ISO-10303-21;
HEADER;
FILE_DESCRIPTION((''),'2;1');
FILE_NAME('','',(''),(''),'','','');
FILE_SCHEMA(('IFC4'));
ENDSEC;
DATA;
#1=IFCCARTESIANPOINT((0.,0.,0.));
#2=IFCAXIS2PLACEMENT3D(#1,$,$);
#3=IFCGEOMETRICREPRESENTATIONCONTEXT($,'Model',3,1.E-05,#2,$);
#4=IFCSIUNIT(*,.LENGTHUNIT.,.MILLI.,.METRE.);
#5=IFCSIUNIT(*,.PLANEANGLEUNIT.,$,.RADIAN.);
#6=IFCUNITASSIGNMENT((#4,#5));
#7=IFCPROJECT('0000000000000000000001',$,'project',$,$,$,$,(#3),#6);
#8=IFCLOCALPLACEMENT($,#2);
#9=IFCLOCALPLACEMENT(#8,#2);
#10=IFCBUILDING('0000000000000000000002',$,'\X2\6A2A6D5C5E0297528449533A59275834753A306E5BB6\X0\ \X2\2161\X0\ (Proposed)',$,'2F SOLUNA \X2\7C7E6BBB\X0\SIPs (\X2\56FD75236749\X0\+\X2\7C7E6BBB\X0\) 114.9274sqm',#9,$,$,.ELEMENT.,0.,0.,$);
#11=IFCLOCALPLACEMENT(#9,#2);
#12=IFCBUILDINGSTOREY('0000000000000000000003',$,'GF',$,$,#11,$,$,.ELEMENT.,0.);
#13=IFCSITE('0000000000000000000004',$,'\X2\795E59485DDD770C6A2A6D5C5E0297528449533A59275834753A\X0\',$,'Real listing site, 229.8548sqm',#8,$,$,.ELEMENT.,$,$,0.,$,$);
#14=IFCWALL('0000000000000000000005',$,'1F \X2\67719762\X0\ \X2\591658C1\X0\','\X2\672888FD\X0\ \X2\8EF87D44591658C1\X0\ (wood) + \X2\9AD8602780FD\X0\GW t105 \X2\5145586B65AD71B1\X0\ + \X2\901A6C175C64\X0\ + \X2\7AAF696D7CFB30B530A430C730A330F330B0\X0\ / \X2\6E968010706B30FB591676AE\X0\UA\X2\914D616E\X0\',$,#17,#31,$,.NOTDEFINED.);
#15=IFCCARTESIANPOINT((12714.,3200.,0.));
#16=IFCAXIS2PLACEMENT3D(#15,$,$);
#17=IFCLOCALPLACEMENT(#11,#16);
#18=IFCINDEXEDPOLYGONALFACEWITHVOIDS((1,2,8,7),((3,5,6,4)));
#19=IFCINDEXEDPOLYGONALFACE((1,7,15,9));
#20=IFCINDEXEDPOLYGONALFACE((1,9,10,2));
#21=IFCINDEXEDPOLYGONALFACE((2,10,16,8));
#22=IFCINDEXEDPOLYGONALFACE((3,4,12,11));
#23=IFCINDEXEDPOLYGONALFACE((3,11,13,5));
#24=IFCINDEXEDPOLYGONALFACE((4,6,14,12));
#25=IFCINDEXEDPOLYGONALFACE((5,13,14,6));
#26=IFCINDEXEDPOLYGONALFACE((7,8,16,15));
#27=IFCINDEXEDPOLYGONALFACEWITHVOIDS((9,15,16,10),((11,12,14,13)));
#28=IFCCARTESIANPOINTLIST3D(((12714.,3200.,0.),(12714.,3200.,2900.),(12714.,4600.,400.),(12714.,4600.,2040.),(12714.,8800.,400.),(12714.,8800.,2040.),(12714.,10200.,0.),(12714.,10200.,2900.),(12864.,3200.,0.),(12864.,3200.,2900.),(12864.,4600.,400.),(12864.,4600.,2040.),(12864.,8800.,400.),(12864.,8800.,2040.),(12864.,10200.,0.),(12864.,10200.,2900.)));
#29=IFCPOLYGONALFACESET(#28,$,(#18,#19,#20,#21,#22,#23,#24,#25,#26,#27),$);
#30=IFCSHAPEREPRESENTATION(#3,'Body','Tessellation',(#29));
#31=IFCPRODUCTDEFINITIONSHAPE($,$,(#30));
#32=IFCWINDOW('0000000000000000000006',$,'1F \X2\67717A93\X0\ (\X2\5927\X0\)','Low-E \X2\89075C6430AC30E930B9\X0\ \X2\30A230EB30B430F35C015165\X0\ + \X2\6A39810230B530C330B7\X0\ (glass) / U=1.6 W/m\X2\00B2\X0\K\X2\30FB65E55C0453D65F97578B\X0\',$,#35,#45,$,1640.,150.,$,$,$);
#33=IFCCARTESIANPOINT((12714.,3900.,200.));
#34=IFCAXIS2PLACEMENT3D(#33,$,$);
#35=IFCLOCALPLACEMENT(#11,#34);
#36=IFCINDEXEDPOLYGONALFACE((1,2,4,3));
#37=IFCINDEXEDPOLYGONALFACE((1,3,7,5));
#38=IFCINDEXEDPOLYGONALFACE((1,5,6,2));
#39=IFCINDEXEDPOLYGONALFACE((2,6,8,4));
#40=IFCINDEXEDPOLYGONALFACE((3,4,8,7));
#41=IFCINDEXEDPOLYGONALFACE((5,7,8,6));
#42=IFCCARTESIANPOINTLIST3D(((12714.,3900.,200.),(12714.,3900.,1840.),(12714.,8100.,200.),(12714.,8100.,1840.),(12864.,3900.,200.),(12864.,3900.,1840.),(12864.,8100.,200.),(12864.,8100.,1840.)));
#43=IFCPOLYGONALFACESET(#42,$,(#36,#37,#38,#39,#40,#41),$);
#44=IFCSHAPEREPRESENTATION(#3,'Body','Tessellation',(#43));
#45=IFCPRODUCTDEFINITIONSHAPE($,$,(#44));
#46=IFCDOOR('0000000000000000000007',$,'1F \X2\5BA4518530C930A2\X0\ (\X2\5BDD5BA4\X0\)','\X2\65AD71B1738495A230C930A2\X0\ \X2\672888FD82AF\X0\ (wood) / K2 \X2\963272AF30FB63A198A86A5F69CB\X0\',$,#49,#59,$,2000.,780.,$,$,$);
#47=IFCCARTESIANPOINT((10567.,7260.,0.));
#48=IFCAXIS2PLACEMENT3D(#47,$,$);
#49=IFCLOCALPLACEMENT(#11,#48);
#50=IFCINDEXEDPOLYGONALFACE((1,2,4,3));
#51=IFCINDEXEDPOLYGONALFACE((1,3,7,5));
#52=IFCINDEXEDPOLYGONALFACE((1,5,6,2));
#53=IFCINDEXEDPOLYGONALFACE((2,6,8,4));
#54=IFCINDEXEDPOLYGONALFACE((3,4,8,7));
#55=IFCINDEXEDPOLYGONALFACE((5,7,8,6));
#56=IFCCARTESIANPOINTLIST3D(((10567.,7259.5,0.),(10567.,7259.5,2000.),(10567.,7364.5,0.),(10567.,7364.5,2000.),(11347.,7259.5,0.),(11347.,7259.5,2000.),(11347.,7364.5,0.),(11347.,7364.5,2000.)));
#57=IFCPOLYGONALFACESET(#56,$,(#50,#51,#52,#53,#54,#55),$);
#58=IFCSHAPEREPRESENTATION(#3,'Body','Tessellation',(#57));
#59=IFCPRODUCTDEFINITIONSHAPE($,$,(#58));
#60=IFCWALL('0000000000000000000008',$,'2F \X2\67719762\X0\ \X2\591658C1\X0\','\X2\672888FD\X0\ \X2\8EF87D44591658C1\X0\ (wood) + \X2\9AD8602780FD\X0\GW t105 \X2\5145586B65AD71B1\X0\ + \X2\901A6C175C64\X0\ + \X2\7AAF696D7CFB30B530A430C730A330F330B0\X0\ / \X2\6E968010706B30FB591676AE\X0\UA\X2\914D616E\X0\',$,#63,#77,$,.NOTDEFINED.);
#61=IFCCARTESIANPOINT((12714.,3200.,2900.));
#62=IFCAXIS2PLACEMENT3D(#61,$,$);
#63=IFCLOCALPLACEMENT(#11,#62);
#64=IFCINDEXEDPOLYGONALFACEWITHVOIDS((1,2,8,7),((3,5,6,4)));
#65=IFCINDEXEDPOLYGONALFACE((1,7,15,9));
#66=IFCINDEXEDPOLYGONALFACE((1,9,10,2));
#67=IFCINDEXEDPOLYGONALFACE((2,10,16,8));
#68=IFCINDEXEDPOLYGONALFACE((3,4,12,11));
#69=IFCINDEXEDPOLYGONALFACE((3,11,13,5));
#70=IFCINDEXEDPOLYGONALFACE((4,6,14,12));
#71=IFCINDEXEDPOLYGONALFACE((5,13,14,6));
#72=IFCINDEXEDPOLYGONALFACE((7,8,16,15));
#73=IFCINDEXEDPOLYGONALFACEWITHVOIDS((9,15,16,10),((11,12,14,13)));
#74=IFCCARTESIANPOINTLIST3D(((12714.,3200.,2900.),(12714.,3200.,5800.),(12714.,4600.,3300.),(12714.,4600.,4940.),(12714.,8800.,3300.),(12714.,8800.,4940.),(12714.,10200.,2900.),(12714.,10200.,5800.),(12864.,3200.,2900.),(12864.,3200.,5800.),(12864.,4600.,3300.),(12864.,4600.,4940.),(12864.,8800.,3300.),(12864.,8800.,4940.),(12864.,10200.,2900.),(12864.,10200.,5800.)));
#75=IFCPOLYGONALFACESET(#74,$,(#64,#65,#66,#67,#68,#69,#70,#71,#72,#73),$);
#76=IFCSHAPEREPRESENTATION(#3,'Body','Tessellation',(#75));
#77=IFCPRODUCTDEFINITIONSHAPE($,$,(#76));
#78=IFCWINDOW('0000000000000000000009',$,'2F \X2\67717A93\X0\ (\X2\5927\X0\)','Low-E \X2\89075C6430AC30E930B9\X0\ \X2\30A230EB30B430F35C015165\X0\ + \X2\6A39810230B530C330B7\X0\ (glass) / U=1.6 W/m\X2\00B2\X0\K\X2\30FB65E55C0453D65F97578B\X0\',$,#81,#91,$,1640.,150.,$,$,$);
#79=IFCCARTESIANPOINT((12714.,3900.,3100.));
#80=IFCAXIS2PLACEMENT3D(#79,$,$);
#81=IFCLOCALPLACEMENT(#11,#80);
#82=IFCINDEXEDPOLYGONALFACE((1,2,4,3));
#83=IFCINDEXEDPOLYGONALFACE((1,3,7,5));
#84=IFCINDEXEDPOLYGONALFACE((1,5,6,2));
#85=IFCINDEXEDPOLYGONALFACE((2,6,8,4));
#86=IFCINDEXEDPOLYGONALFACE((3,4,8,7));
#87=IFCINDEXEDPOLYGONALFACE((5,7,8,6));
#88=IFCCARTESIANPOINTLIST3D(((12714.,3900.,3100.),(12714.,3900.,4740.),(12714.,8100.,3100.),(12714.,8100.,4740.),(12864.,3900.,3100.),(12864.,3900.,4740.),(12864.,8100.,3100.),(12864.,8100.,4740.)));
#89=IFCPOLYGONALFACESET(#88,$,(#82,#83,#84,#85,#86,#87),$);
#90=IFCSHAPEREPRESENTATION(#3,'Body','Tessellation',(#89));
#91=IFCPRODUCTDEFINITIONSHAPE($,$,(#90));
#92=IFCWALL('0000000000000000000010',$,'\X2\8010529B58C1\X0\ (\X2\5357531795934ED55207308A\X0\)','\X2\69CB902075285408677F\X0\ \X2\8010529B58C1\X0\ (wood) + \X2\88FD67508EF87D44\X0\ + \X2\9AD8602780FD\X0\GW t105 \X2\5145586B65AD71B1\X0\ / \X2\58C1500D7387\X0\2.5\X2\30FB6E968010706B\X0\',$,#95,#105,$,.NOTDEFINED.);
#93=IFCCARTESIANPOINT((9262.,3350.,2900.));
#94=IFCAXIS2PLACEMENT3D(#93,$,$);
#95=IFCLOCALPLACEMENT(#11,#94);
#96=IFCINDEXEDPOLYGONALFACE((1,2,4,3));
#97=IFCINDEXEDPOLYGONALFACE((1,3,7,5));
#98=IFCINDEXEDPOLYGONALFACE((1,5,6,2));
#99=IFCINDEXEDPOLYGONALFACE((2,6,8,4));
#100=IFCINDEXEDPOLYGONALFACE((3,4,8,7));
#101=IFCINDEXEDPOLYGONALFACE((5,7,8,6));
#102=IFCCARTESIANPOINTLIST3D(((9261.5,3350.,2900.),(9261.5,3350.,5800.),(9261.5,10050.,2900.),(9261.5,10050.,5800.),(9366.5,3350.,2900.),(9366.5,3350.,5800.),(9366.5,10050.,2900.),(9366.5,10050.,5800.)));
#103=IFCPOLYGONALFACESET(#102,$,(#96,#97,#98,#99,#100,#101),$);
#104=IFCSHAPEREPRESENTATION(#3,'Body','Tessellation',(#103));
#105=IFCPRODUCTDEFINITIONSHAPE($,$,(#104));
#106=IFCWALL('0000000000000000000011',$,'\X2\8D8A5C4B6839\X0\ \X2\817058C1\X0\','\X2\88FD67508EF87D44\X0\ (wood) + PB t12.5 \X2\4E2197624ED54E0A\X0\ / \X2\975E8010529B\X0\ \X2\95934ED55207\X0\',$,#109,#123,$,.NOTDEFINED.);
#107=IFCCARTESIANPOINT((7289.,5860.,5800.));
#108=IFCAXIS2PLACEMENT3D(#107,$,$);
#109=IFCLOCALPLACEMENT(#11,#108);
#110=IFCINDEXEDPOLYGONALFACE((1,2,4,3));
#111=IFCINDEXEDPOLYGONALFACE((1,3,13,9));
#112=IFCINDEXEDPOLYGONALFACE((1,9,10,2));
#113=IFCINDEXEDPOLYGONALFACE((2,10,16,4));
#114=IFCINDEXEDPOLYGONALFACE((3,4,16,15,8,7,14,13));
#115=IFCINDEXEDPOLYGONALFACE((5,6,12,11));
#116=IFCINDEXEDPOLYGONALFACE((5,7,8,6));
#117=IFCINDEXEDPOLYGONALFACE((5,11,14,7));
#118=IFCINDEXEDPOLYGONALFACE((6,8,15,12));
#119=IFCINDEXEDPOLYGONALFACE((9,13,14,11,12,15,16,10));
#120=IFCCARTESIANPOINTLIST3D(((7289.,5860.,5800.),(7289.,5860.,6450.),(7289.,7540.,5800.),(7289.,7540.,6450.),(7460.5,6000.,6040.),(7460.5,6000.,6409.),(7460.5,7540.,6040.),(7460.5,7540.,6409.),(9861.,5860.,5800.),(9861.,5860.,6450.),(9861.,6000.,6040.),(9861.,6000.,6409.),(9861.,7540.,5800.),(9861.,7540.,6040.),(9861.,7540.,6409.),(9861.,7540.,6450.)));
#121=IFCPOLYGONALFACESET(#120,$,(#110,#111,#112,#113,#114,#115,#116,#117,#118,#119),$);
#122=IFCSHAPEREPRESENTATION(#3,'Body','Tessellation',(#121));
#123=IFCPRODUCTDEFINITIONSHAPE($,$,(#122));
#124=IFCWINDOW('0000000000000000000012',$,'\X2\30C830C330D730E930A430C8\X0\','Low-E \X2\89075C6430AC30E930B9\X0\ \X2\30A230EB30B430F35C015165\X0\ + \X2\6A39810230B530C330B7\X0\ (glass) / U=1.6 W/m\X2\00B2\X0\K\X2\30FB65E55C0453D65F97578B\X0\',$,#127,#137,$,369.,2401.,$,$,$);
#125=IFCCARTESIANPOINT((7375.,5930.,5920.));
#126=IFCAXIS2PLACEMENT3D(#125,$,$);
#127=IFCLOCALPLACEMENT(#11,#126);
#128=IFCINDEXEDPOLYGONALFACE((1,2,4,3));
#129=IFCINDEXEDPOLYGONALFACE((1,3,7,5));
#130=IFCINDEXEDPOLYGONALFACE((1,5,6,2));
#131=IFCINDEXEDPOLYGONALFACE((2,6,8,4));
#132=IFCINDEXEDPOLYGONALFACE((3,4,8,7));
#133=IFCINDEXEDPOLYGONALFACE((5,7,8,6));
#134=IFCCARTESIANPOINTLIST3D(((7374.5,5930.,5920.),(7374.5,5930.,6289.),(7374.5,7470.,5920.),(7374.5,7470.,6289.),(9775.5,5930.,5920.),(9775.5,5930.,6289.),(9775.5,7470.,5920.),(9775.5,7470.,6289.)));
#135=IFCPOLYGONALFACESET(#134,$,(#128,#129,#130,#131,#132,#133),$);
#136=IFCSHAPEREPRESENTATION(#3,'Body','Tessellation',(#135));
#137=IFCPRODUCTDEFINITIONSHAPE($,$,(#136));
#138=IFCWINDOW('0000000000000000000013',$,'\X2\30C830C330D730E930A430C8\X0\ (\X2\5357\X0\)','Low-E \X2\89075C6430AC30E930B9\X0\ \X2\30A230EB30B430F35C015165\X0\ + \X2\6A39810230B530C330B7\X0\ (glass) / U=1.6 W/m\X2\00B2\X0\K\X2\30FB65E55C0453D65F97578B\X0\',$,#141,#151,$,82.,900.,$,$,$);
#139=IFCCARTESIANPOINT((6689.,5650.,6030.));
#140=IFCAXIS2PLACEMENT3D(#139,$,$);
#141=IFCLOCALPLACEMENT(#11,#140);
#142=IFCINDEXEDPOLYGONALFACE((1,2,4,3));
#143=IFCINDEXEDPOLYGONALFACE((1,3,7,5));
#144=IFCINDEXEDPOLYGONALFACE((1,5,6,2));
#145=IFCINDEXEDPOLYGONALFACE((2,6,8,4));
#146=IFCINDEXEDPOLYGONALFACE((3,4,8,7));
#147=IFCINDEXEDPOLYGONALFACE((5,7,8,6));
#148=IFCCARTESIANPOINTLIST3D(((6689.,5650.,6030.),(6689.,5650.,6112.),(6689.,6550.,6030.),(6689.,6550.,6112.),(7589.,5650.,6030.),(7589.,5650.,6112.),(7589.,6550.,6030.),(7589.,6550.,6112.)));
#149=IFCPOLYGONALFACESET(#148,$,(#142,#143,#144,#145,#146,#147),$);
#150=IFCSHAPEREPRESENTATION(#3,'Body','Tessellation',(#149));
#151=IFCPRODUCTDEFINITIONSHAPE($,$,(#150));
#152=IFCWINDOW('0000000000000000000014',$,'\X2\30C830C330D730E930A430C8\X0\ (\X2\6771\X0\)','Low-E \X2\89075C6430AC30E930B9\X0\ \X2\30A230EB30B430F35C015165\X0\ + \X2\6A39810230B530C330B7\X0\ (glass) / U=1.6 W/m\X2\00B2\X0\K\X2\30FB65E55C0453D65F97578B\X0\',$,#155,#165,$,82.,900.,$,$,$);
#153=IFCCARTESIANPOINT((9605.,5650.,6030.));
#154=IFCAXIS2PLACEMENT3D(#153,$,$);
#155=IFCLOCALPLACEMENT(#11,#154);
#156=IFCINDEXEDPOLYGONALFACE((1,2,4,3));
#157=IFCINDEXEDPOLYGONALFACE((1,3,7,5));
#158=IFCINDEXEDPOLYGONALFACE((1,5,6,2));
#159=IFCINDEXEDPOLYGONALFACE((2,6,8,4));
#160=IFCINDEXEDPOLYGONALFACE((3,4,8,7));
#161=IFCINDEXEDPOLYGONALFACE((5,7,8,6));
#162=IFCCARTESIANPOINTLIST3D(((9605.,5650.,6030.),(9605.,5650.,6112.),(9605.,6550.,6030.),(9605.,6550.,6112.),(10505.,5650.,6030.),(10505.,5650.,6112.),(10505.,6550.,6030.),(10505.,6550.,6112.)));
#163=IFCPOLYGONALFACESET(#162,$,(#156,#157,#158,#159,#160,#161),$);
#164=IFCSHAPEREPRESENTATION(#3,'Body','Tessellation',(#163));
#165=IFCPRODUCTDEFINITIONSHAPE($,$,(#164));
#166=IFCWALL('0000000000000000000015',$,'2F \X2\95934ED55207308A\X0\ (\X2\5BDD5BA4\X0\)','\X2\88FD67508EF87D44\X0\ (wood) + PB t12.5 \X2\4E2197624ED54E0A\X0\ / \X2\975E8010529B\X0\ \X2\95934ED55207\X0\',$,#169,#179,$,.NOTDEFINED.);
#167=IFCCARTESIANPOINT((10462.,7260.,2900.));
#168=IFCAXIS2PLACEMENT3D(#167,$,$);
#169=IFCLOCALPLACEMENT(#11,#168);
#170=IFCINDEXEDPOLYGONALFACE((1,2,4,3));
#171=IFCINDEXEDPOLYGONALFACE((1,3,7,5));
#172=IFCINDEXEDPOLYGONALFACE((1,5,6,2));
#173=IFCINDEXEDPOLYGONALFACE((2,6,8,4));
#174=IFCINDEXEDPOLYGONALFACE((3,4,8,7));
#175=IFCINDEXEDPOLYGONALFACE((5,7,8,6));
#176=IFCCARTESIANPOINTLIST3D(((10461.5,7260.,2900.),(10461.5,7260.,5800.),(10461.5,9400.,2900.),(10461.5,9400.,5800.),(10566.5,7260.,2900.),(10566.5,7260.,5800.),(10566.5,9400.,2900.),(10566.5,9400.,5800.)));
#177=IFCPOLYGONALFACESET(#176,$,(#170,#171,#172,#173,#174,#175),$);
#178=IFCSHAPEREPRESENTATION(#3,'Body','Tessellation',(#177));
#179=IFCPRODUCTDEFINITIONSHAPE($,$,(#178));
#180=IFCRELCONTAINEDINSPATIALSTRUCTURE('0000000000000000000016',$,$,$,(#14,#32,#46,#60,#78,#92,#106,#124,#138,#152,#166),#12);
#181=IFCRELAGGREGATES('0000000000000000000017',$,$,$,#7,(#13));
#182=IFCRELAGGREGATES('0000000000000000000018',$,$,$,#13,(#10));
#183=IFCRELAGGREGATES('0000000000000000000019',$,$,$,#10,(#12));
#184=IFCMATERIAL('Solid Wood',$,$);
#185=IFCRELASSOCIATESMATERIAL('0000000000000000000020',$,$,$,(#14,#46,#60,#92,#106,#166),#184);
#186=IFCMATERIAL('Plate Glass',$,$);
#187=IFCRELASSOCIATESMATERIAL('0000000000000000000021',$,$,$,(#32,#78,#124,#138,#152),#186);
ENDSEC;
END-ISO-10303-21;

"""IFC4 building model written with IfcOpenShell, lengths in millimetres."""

from ifc_helpers import new_model, si_unit, frame, frame_2d, origin, place, context, project, spatial, rectangle, extrude, material, element, fill, save


model = new_model("IFC4")

# Units and contexts
model_context = context("Model", 3, precision=1e-05, world=origin())
ifc_project = project(units=[si_unit("LENGTHUNIT", "METRE", prefix="MILLI"), si_unit("PLANEANGLEUNIT", "RADIAN")], contexts=[model_context])

# Site, building, storey
site_placement = place(None, origin())
site = spatial("IfcSite", under=ifc_project, at=site_placement, Name="神奈川県横浜市青葉区大場町", ObjectType="Real listing site, 229.8548sqm", CompositionType="ELEMENT", RefElevation=0.0)
building_placement = place(site_placement, origin())
building = spatial("IfcBuilding", under=site, at=building_placement, Name="横浜市青葉区大場町の家 Ⅱ (Proposed)", ObjectType="2F SOLUNA 籾殻SIPs (国産杉+籾殻) 114.9274sqm", CompositionType="ELEMENT", ElevationOfRefHeight=0.0, ElevationOfTerrain=0.0)
storey_placement = place(building_placement, origin())
storey = spatial("IfcBuildingStorey", under=building, at=storey_placement, Name="GF", CompositionType="ELEMENT", Elevation=0.0)

# Wall, opening, window
ifc_material_1 = material(Name="Solid Wood")
wall_1_placement = place(storey_placement, frame((12714.0, 3200.0, 0.0)))
wall_1 = element("IfcWall", 1, at=wall_1_placement, inside=storey, material=ifc_material_1, Name="1F 東面 外壁", Description="木製 軸組外壁 (wood) + 高性能GW t105 充填断熱 + 通気層 + 窯業系サイディング / 準耐火・外皮UA配慮", PredefinedType="NOTDEFINED", context=model_context, shape_type="SweptSolid", body=[
    extrude(rectangle(XDim=150.0, YDim=7000.0, at=frame_2d((75.0, 3500.0))), frame((12714.0, 3200.0, 0.0)), (0.0, 0.0, 1.0), 2900.0),
])
opening_1_placement = place(storey_placement, frame((12714.0, 3900.0, 200.0)))
opening_1 = element("IfcOpeningElement", 2, at=opening_1_placement, cuts=wall_1, PredefinedType="NOTDEFINED", context=model_context, shape_type="SweptSolid", body=[
    extrude(rectangle(XDim=150.0, YDim=4200.0, at=frame_2d((75.0, 2100.0))), frame((12714.0, 3900.0, 200.0)), (0.0, 0.0, 1.0), 1640.0),
])
ifc_material_2 = material(Name="Plate Glass")
window_1_placement = place(storey_placement, frame((12714.0, 3900.0, 200.0)))
window_1 = element("IfcWindow", 3, at=window_1_placement, inside=storey, material=ifc_material_2, Name="1F 東窓 (大)", Description="Low-E 複層ガラス アルゴン封入 + 樹脂サッシ (glass) / U=1.6 W/m²K・日射取得型", OverallHeight=1640.0, OverallWidth=150.0, context=model_context, shape_type="SweptSolid", body=[
    extrude(rectangle(XDim=150.0, YDim=4200.0, at=frame_2d((75.0, 2100.0))), frame((12714.0, 3900.0, 200.0)), (0.0, 0.0, 1.0), 1640.0),
])
fill(opening_1, window_1)

# Door
door_1_placement = place(storey_placement, frame((10567.0, 7260.0, 0.0)))
element("IfcDoor", 4, at=door_1_placement, inside=storey, material=ifc_material_1, Name="1F 室内ドア (寝室)", Description="断熱玄関ドア 木製芯 (wood) / K2 防犯・採風機構", OverallHeight=2000.0, OverallWidth=780.0, context=model_context, shape_type="SweptSolid", body=[
    extrude(rectangle(XDim=780.0, YDim=105.0, at=frame_2d((390.0, 52.0))), frame((10567.0, 7260.0, 0.0)), (0.0, 0.0, 1.0), 2000.0),
])

# Wall, opening, window
wall_2_placement = place(storey_placement, frame((12714.0, 3200.0, 2900.0)))
wall_2 = element("IfcWall", 5, at=wall_2_placement, inside=storey, material=ifc_material_1, Name="2F 東面 外壁", Description="木製 軸組外壁 (wood) + 高性能GW t105 充填断熱 + 通気層 + 窯業系サイディング / 準耐火・外皮UA配慮", PredefinedType="NOTDEFINED", context=model_context, shape_type="SweptSolid", body=[
    extrude(rectangle(XDim=150.0, YDim=7000.0, at=frame_2d((75.0, 3500.0))), frame((12714.0, 3200.0, 2900.0)), (0.0, 0.0, 1.0), 2900.0),
])
opening_2_placement = place(storey_placement, frame((12714.0, 3900.0, 3100.0)))
opening_2 = element("IfcOpeningElement", 6, at=opening_2_placement, cuts=wall_2, PredefinedType="NOTDEFINED", context=model_context, shape_type="SweptSolid", body=[
    extrude(rectangle(XDim=150.0, YDim=4200.0, at=frame_2d((75.0, 2100.0))), frame((12714.0, 3900.0, 3100.0)), (0.0, 0.0, 1.0), 1640.0),
])
window_2_placement = place(storey_placement, frame((12714.0, 3900.0, 3100.0)))
window_2 = element("IfcWindow", 7, at=window_2_placement, inside=storey, material=ifc_material_2, Name="2F 東窓 (大)", Description="Low-E 複層ガラス アルゴン封入 + 樹脂サッシ (glass) / U=1.6 W/m²K・日射取得型", OverallHeight=1640.0, OverallWidth=150.0, context=model_context, shape_type="SweptSolid", body=[
    extrude(rectangle(XDim=150.0, YDim=4200.0, at=frame_2d((75.0, 2100.0))), frame((12714.0, 3900.0, 3100.0)), (0.0, 0.0, 1.0), 1640.0),
])
fill(opening_2, window_2)

# Wall
wall_3_placement = place(storey_placement, frame((9262.0, 3350.0, 2900.0)))
element("IfcWall", 8, at=wall_3_placement, inside=storey, material=ifc_material_1, Name="耐力壁 (南北間仕切り)", Description="構造用合板 耐力壁 (wood) + 製材軸組 + 高性能GW t105 充填断熱 / 壁倍率2.5・準耐火", PredefinedType="NOTDEFINED", context=model_context, shape_type="SweptSolid", body=[
    extrude(rectangle(XDim=105.0, YDim=6700.0, at=frame_2d((52.0, 3350.0))), frame((9262.0, 3350.0, 2900.0)), (0.0, 0.0, 1.0), 2900.0),
])

# Wall, openings, windows
wall_4_placement = place(storey_placement, frame((7289.0, 5860.0, 5800.0)))
wall_4 = element("IfcWall", 9, at=wall_4_placement, inside=storey, material=ifc_material_1, Name="越屋根 腰壁", Description="製材軸組 (wood) + PB t12.5 両面仕上 / 非耐力 間仕切", PredefinedType="NOTDEFINED", context=model_context, shape_type="SweptSolid", body=[
    extrude(rectangle(XDim=2572.0, YDim=1680.0, at=frame_2d((1286.0, 840.0))), frame((7289.0, 5860.0, 5800.0)), (0.0, 0.0, 1.0), 650.0),
])
opening_3_placement = place(storey_placement, frame((7375.0, 5930.0, 5920.0)))
opening_3 = element("IfcOpeningElement", 10, at=opening_3_placement, cuts=wall_4, PredefinedType="NOTDEFINED", context=model_context, shape_type="SweptSolid", body=[
    extrude(rectangle(XDim=2401.0, YDim=1540.0, at=frame_2d((1200.0, 770.0))), frame((7375.0, 5930.0, 5920.0)), (0.0, 0.0, 1.0), 369.0),
])
opening_4_placement = place(storey_placement, frame((6689.0, 5650.0, 6030.0)))
opening_4 = element("IfcOpeningElement", 11, at=opening_4_placement, cuts=wall_4, PredefinedType="NOTDEFINED", context=model_context, shape_type="SweptSolid", body=[
    extrude(rectangle(XDim=900.0, YDim=900.0, at=frame_2d((450.0, 450.0))), frame((6689.0, 5650.0, 6030.0)), (0.0, 0.0, 1.0), 82.0),
])
opening_5_placement = place(storey_placement, frame((9605.0, 5650.0, 6030.0)))
opening_5 = element("IfcOpeningElement", 12, at=opening_5_placement, cuts=wall_4, PredefinedType="NOTDEFINED", context=model_context, shape_type="SweptSolid", body=[
    extrude(rectangle(XDim=900.0, YDim=900.0, at=frame_2d((450.0, 450.0))), frame((9605.0, 5650.0, 6030.0)), (0.0, 0.0, 1.0), 82.0),
])
window_3_placement = place(storey_placement, frame((7375.0, 5930.0, 5920.0)))
window_3 = element("IfcWindow", 13, at=window_3_placement, inside=storey, material=ifc_material_2, Name="トップライト", Description="Low-E 複層ガラス アルゴン封入 + 樹脂サッシ (glass) / U=1.6 W/m²K・日射取得型", OverallHeight=369.0, OverallWidth=2401.0, context=model_context, shape_type="SweptSolid", body=[
    extrude(rectangle(XDim=2401.0, YDim=1540.0, at=frame_2d((1200.0, 770.0))), frame((7375.0, 5930.0, 5920.0)), (0.0, 0.0, 1.0), 369.0),
])
fill(opening_3, window_3)
window_4_placement = place(storey_placement, frame((6689.0, 5650.0, 6030.0)))
window_4 = element("IfcWindow", 14, at=window_4_placement, inside=storey, material=ifc_material_2, Name="トップライト (南)", Description="Low-E 複層ガラス アルゴン封入 + 樹脂サッシ (glass) / U=1.6 W/m²K・日射取得型", OverallHeight=82.0, OverallWidth=900.0, context=model_context, shape_type="SweptSolid", body=[
    extrude(rectangle(XDim=900.0, YDim=900.0, at=frame_2d((450.0, 450.0))), frame((6689.0, 5650.0, 6030.0)), (0.0, 0.0, 1.0), 82.0),
])
fill(opening_4, window_4)
window_5_placement = place(storey_placement, frame((9605.0, 5650.0, 6030.0)))
window_5 = element("IfcWindow", 15, at=window_5_placement, inside=storey, material=ifc_material_2, Name="トップライト (東)", Description="Low-E 複層ガラス アルゴン封入 + 樹脂サッシ (glass) / U=1.6 W/m²K・日射取得型", OverallHeight=82.0, OverallWidth=900.0, context=model_context, shape_type="SweptSolid", body=[
    extrude(rectangle(XDim=900.0, YDim=900.0, at=frame_2d((450.0, 450.0))), frame((9605.0, 5650.0, 6030.0)), (0.0, 0.0, 1.0), 82.0),
])
fill(opening_5, window_5)

# Wall
wall_5_placement = place(storey_placement, frame((10462.0, 7260.0, 2900.0)))
element("IfcWall", 16, at=wall_5_placement, inside=storey, material=ifc_material_1, Name="2F 間仕切り (寝室)", Description="製材軸組 (wood) + PB t12.5 両面仕上 / 非耐力 間仕切", PredefinedType="NOTDEFINED", context=model_context, shape_type="SweptSolid", body=[
    extrude(rectangle(XDim=105.0, YDim=2140.0, at=frame_2d((52.0, 1070.0))), frame((10462.0, 7260.0, 2900.0)), (0.0, 0.0, 1.0), 2900.0),
])

save(model, "model.ifc")
